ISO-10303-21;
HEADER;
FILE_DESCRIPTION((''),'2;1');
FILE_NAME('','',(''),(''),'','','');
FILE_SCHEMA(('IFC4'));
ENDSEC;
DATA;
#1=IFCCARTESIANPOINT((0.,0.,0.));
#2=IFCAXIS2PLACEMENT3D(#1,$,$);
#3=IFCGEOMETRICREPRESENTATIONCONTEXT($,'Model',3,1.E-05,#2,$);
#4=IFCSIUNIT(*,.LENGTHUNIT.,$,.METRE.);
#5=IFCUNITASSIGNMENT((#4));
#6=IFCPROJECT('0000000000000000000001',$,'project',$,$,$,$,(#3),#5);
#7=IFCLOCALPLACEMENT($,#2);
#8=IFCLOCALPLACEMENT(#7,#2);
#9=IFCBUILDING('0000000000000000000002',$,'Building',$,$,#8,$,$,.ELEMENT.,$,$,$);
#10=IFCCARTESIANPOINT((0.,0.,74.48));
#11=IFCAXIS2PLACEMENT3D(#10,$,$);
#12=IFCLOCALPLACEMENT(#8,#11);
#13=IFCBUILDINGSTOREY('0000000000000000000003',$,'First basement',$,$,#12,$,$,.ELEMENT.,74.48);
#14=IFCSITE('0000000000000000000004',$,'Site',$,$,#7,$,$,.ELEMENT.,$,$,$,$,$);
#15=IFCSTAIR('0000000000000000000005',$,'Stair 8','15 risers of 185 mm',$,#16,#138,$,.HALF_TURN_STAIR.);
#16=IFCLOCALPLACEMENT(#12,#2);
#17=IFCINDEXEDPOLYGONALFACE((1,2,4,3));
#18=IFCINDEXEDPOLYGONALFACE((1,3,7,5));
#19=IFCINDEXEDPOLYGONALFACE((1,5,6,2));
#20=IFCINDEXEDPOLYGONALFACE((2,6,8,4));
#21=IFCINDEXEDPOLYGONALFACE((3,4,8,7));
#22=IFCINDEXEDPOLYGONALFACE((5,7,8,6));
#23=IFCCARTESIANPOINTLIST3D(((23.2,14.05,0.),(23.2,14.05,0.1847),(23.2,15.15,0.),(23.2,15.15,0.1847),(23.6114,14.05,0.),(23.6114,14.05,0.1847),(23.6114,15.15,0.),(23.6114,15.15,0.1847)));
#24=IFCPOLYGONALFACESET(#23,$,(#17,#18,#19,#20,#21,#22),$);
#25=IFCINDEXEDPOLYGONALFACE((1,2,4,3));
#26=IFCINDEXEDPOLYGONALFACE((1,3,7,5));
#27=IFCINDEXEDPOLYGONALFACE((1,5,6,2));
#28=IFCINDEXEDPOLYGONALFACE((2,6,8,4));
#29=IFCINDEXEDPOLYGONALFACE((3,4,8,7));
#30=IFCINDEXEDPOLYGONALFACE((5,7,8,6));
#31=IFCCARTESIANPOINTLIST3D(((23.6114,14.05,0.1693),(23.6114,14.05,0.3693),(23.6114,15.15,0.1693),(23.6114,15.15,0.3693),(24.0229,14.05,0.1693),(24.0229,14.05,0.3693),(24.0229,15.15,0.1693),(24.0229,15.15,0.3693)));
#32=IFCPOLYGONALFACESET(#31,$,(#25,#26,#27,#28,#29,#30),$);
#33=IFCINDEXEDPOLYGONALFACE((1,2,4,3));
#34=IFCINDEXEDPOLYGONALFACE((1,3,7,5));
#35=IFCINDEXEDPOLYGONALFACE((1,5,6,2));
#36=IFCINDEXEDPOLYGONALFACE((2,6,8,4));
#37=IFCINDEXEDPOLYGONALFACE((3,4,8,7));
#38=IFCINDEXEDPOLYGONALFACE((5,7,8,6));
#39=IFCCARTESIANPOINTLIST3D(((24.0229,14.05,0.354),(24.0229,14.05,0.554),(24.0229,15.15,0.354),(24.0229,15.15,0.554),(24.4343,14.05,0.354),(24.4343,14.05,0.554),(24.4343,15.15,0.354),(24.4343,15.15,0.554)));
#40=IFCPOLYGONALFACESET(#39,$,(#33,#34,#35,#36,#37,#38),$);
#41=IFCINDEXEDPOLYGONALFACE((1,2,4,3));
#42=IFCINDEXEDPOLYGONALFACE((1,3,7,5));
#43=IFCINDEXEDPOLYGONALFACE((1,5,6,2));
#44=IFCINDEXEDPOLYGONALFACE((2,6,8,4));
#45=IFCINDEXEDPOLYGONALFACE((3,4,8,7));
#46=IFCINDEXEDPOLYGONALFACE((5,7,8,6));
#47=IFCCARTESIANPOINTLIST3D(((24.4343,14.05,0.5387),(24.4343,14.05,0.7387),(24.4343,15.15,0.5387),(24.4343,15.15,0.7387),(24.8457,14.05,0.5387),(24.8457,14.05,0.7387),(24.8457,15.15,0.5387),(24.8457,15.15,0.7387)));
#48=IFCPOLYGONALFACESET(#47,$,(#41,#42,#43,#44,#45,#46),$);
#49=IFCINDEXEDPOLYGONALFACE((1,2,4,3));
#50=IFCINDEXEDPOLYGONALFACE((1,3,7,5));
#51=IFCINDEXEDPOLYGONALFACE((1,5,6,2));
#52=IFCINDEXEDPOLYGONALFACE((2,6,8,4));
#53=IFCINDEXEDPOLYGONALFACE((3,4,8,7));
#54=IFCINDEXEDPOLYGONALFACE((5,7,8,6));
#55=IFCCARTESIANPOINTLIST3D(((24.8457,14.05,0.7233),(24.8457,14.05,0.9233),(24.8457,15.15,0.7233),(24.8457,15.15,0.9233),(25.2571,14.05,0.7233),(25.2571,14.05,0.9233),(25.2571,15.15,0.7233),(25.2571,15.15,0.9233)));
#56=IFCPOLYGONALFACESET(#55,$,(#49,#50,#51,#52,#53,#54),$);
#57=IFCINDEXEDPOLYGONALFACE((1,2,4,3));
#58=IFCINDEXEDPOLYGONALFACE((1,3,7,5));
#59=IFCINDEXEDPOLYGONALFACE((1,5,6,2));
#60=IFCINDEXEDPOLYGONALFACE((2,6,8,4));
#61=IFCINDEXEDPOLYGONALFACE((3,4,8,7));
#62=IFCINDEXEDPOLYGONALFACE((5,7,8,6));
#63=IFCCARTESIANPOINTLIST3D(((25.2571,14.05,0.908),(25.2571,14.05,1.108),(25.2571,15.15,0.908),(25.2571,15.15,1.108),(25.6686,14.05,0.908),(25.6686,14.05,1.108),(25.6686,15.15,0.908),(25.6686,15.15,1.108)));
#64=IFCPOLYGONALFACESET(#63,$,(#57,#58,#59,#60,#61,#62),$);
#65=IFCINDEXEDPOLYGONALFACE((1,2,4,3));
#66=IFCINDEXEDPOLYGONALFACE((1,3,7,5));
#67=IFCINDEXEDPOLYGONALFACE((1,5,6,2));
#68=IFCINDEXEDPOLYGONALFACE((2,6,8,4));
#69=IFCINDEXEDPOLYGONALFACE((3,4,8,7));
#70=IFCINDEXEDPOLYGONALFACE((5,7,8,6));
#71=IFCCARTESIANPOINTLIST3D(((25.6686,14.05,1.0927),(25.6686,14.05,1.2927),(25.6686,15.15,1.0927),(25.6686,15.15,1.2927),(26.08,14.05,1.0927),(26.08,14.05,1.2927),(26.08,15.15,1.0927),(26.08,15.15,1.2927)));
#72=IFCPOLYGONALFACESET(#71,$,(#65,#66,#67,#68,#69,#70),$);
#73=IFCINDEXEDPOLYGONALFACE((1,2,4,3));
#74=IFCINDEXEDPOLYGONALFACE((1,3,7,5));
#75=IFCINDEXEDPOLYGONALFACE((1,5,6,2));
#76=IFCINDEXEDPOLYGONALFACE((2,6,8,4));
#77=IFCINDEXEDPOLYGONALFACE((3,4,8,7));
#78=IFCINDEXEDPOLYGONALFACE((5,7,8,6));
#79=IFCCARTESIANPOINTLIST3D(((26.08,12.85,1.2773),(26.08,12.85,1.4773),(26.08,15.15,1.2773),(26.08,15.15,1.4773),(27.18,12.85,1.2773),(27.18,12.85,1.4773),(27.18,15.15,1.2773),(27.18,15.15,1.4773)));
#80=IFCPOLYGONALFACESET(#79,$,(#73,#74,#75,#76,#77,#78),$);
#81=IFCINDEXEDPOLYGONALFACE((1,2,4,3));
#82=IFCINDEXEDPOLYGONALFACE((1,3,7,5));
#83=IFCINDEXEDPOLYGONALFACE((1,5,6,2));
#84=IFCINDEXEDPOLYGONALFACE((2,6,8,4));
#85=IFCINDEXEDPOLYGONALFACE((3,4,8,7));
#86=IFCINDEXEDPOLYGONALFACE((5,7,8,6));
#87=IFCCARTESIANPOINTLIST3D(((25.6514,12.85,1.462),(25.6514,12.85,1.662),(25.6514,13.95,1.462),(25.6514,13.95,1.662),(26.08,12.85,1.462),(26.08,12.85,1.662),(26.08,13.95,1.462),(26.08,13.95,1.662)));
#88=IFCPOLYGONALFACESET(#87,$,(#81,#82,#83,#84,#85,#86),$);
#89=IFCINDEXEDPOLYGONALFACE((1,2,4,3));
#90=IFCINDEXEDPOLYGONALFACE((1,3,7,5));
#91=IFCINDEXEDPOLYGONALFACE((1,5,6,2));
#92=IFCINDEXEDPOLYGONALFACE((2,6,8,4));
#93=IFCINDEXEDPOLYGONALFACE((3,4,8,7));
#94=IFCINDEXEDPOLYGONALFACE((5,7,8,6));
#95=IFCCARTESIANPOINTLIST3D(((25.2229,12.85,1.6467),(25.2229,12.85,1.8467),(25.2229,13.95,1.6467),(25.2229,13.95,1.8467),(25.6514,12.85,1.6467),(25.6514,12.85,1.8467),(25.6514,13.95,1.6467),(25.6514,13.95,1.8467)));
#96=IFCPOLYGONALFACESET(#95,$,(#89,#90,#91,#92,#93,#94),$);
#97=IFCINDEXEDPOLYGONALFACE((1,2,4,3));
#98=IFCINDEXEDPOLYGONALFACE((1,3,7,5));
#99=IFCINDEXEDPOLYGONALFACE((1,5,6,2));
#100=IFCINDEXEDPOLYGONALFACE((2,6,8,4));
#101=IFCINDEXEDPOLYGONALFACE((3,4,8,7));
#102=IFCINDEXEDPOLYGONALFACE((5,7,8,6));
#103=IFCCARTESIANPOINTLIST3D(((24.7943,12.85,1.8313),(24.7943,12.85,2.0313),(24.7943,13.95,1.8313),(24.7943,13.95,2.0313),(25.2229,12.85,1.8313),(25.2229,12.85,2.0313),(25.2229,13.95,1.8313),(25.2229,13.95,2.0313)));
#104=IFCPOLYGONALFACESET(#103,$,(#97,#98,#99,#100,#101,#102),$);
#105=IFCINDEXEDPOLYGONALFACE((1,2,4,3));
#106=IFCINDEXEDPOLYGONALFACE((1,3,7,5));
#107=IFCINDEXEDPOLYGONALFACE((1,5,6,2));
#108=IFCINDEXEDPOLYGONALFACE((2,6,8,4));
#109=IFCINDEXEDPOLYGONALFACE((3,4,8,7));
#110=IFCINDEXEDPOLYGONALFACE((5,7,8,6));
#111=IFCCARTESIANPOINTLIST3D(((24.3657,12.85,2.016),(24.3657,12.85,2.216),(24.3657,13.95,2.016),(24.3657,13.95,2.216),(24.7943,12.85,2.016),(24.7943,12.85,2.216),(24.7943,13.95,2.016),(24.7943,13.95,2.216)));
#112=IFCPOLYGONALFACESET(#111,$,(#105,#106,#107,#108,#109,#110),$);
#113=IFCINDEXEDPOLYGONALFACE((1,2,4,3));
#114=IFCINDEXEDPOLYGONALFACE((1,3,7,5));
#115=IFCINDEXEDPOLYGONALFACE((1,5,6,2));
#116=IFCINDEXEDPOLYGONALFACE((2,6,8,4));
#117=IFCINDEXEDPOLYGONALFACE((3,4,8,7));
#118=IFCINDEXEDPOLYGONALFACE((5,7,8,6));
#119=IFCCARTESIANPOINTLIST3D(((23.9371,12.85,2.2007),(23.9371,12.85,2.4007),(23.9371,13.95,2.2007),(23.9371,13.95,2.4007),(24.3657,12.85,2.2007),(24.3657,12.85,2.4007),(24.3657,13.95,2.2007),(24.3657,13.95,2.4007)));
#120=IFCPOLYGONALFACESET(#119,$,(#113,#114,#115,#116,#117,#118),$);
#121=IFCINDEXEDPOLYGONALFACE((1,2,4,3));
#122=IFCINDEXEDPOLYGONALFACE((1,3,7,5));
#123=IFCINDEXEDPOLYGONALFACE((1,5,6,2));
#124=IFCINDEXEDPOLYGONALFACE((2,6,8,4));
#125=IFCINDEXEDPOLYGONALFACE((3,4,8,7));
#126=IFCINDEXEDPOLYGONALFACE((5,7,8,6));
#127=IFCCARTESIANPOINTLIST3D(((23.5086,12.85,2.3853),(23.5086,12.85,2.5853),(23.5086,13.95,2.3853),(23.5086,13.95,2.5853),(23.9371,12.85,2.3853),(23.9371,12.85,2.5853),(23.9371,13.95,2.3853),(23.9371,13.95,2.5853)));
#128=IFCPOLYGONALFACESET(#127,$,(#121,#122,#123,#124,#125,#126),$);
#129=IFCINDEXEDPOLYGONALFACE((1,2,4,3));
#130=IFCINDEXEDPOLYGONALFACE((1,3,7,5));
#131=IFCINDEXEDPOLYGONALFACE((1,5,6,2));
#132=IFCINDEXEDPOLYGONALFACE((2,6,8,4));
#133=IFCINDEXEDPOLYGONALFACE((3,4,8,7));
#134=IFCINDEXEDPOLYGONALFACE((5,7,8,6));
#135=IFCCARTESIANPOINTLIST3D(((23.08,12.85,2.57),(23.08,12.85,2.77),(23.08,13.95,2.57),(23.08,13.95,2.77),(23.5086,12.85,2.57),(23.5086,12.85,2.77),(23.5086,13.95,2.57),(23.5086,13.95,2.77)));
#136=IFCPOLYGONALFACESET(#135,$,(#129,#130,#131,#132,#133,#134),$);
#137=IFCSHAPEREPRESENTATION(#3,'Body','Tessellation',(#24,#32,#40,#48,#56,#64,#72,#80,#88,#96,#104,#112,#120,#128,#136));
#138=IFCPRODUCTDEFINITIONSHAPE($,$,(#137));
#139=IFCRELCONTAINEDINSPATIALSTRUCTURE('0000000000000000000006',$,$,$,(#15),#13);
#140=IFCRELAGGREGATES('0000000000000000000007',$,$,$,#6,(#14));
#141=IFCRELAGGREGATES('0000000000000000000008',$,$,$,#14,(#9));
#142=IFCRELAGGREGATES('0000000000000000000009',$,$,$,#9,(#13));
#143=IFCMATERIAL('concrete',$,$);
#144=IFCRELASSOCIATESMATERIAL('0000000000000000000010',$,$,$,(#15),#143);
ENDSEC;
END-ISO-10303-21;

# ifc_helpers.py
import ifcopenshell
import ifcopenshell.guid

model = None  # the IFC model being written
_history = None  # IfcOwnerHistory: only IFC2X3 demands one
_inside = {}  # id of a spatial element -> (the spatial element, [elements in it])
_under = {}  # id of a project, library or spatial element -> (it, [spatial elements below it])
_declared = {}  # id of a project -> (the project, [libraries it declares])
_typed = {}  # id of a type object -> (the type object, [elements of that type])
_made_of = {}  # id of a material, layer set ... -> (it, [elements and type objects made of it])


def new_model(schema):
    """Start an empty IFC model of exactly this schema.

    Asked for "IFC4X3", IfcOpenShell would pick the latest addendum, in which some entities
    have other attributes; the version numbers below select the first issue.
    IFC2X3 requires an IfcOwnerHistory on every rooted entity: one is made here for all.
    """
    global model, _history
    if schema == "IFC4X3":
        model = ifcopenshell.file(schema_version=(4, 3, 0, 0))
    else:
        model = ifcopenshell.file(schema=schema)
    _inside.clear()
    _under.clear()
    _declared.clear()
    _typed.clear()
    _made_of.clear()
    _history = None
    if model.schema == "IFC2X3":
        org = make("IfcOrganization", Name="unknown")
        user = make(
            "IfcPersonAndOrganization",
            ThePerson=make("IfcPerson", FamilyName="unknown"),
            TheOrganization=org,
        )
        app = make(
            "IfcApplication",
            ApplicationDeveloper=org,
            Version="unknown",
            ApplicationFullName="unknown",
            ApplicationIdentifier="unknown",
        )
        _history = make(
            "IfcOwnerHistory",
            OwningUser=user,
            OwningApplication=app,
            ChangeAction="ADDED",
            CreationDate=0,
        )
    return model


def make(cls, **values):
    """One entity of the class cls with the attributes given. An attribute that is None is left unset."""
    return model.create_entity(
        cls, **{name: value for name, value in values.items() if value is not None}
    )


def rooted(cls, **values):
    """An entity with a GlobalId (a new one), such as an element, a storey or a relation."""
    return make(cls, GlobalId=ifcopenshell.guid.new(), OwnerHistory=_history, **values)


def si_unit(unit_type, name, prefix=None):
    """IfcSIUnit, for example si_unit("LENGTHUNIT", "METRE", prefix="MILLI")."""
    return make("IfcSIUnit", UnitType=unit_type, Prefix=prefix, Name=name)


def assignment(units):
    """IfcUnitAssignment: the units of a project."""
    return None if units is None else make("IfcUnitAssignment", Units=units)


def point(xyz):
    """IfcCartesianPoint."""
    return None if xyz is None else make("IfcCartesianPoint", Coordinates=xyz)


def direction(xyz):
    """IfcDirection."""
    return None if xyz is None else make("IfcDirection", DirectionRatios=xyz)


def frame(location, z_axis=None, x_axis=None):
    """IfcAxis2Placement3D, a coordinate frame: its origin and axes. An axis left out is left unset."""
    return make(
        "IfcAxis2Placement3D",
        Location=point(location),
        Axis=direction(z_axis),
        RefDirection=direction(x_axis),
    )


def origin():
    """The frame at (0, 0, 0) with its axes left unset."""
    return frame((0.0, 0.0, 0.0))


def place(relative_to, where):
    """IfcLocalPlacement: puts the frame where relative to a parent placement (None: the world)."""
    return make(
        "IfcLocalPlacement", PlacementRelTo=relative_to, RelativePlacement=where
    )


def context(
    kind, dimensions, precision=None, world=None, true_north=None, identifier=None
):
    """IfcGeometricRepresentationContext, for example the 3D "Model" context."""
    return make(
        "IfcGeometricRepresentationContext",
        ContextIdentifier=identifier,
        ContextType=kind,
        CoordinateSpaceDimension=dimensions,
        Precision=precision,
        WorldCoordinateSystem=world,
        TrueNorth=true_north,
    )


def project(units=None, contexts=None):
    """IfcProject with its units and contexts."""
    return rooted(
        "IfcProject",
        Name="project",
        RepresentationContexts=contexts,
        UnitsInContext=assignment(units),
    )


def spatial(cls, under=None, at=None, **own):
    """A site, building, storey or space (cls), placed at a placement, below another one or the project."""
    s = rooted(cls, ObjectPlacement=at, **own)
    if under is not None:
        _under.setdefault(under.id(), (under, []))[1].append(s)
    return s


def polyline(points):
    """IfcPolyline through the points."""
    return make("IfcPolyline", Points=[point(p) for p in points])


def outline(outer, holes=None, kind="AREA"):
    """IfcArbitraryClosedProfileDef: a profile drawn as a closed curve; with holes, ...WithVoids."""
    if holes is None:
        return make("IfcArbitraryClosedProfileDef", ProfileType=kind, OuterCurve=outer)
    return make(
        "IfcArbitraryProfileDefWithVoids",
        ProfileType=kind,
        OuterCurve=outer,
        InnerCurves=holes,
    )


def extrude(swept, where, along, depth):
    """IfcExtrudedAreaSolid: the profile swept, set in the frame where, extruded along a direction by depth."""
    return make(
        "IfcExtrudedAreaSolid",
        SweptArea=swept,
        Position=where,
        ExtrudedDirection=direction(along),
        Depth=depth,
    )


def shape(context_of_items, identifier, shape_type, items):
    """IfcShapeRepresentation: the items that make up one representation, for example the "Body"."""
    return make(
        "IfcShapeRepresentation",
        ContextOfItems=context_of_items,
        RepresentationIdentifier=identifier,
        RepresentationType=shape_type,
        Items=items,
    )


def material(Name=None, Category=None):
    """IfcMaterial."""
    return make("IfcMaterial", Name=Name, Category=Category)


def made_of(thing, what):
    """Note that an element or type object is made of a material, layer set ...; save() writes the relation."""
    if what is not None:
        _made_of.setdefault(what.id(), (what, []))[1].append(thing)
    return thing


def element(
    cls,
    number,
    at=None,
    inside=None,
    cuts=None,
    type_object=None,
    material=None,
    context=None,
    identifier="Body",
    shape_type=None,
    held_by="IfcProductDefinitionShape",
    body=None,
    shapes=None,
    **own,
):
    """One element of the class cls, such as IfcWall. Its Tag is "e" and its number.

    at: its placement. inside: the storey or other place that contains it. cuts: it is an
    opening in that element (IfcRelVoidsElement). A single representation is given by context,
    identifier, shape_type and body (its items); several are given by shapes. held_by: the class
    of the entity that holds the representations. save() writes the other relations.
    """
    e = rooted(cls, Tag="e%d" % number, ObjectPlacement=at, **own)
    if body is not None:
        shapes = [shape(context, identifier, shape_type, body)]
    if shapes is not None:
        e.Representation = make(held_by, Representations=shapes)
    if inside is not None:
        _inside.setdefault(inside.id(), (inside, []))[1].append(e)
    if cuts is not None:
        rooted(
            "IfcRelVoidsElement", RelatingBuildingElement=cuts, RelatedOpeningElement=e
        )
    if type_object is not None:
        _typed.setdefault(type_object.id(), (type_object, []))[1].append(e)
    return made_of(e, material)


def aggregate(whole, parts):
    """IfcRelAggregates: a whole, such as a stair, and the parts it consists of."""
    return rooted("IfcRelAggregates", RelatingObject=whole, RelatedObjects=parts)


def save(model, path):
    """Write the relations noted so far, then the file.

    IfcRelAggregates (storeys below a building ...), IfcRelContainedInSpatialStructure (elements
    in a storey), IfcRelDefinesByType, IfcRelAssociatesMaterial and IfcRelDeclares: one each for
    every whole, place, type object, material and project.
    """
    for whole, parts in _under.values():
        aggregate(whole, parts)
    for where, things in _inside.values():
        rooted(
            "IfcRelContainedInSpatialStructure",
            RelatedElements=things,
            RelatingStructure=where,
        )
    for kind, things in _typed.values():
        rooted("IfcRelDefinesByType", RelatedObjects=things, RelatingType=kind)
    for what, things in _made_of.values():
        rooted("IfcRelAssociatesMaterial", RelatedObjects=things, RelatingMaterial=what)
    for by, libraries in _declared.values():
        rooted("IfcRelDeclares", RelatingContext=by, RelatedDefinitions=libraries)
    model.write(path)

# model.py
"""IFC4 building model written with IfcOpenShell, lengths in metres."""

from ifc_helpers import new_model, si_unit, frame, origin, place, context, project, spatial, polyline, outline, extrude, material, element, save


model = new_model("IFC4")

# Units and contexts
model_context = context("Model", 3, precision=1e-05, world=origin())
ifc_project = project(units=[si_unit("LENGTHUNIT", "METRE")], contexts=[model_context])

# Site, building, storey
site_placement = place(None, origin())
site = spatial("IfcSite", under=ifc_project, at=site_placement, Name="Site", CompositionType="ELEMENT")
building_placement = place(site_placement, origin())
building = spatial("IfcBuilding", under=site, at=building_placement, Name="Building", CompositionType="ELEMENT")
storey_placement = place(building_placement, frame((0.0, 0.0, 74.48)))
storey = spatial("IfcBuildingStorey", under=building, at=storey_placement, Name="First basement", CompositionType="ELEMENT", Elevation=74.48)

# Shared definitions
ifc_material = material(Name="concrete")

# Stair
stair_1_placement = place(storey_placement, frame((23.2, 14.6, 0.0), z_axis=(0.0, 0.0, 1.0), x_axis=(1.0, 0.0, 0.0)))
element("IfcStair", 1, at=stair_1_placement, inside=storey, material=ifc_material, Name="Stair 8", Description="15 risers of 185 mm", PredefinedType="HALF_TURN_STAIR", context=model_context, shape_type="SweptSolid", body=[
    extrude(outline(polyline([(0.0, -0.55), (0.4114, -0.55), (0.4114, 0.55), (0.0, 0.55), (0.0, -0.55)])), origin(), (0.0, 0.0, 1.0), 0.1847),
    extrude(outline(polyline([(0.4114, -0.55), (0.8229, -0.55), (0.8229, 0.55), (0.4114, 0.55), (0.4114, -0.55)])), frame((0.0, 0.0, 0.1693)), (0.0, 0.0, 1.0), 0.2),
    extrude(outline(polyline([(0.8229, -0.55), (1.2343, -0.55), (1.2343, 0.55), (0.8229, 0.55), (0.8229, -0.55)])), frame((0.0, 0.0, 0.354)), (0.0, 0.0, 1.0), 0.2),
    extrude(outline(polyline([(1.2343, -0.55), (1.6457, -0.55), (1.6457, 0.55), (1.2343, 0.55), (1.2343, -0.55)])), frame((0.0, 0.0, 0.5387)), (0.0, 0.0, 1.0), 0.2),
    extrude(outline(polyline([(1.6457, -0.55), (2.0571, -0.55), (2.0571, 0.55), (1.6457, 0.55), (1.6457, -0.55)])), frame((0.0, 0.0, 0.7233)), (0.0, 0.0, 1.0), 0.2),
    extrude(outline(polyline([(2.0571, -0.55), (2.4686, -0.55), (2.4686, 0.55), (2.0571, 0.55), (2.0571, -0.55)])), frame((0.0, 0.0, 0.908)), (0.0, 0.0, 1.0), 0.2),
    extrude(outline(polyline([(2.4686, -0.55), (2.88, -0.55), (2.88, 0.55), (2.4686, 0.55), (2.4686, -0.55)])), frame((0.0, 0.0, 1.0927)), (0.0, 0.0, 1.0), 0.2),
    extrude(outline(polyline([(2.88, -1.75), (3.98, -1.75), (3.98, 0.55), (2.88, 0.55), (2.88, -1.75)])), frame((0.0, 0.0, 1.2773)), (0.0, 0.0, 1.0), 0.2),
    extrude(outline(polyline([(2.4514, -1.75), (2.88, -1.75), (2.88, -0.65), (2.4514, -0.65), (2.4514, -1.75)])), frame((0.0, 0.0, 1.462)), (0.0, 0.0, 1.0), 0.2),
    extrude(outline(polyline([(2.0229, -1.75), (2.4514, -1.75), (2.4514, -0.65), (2.0229, -0.65), (2.0229, -1.75)])), frame((0.0, 0.0, 1.6467)), (0.0, 0.0, 1.0), 0.2),
    extrude(outline(polyline([(1.5943, -1.75), (2.0229, -1.75), (2.0229, -0.65), (1.5943, -0.65), (1.5943, -1.75)])), frame((0.0, 0.0, 1.8313)), (0.0, 0.0, 1.0), 0.2),
    extrude(outline(polyline([(1.1657, -1.75), (1.5943, -1.75), (1.5943, -0.65), (1.1657, -0.65), (1.1657, -1.75)])), frame((0.0, 0.0, 2.016)), (0.0, 0.0, 1.0), 0.2),
    extrude(outline(polyline([(0.7371, -1.75), (1.1657, -1.75), (1.1657, -0.65), (0.7371, -0.65), (0.7371, -1.75)])), frame((0.0, 0.0, 2.2007)), (0.0, 0.0, 1.0), 0.2),
    extrude(outline(polyline([(0.3086, -1.75), (0.7371, -1.75), (0.7371, -0.65), (0.3086, -0.65), (0.3086, -1.75)])), frame((0.0, 0.0, 2.3853)), (0.0, 0.0, 1.0), 0.2),
    extrude(outline(polyline([(-0.12, -1.75), (0.3086, -1.75), (0.3086, -0.65), (-0.12, -0.65), (-0.12, -1.75)])), frame((0.0, 0.0, 2.57)), (0.0, 0.0, 1.0), 0.2),
])

save(model, "model.ifc")
